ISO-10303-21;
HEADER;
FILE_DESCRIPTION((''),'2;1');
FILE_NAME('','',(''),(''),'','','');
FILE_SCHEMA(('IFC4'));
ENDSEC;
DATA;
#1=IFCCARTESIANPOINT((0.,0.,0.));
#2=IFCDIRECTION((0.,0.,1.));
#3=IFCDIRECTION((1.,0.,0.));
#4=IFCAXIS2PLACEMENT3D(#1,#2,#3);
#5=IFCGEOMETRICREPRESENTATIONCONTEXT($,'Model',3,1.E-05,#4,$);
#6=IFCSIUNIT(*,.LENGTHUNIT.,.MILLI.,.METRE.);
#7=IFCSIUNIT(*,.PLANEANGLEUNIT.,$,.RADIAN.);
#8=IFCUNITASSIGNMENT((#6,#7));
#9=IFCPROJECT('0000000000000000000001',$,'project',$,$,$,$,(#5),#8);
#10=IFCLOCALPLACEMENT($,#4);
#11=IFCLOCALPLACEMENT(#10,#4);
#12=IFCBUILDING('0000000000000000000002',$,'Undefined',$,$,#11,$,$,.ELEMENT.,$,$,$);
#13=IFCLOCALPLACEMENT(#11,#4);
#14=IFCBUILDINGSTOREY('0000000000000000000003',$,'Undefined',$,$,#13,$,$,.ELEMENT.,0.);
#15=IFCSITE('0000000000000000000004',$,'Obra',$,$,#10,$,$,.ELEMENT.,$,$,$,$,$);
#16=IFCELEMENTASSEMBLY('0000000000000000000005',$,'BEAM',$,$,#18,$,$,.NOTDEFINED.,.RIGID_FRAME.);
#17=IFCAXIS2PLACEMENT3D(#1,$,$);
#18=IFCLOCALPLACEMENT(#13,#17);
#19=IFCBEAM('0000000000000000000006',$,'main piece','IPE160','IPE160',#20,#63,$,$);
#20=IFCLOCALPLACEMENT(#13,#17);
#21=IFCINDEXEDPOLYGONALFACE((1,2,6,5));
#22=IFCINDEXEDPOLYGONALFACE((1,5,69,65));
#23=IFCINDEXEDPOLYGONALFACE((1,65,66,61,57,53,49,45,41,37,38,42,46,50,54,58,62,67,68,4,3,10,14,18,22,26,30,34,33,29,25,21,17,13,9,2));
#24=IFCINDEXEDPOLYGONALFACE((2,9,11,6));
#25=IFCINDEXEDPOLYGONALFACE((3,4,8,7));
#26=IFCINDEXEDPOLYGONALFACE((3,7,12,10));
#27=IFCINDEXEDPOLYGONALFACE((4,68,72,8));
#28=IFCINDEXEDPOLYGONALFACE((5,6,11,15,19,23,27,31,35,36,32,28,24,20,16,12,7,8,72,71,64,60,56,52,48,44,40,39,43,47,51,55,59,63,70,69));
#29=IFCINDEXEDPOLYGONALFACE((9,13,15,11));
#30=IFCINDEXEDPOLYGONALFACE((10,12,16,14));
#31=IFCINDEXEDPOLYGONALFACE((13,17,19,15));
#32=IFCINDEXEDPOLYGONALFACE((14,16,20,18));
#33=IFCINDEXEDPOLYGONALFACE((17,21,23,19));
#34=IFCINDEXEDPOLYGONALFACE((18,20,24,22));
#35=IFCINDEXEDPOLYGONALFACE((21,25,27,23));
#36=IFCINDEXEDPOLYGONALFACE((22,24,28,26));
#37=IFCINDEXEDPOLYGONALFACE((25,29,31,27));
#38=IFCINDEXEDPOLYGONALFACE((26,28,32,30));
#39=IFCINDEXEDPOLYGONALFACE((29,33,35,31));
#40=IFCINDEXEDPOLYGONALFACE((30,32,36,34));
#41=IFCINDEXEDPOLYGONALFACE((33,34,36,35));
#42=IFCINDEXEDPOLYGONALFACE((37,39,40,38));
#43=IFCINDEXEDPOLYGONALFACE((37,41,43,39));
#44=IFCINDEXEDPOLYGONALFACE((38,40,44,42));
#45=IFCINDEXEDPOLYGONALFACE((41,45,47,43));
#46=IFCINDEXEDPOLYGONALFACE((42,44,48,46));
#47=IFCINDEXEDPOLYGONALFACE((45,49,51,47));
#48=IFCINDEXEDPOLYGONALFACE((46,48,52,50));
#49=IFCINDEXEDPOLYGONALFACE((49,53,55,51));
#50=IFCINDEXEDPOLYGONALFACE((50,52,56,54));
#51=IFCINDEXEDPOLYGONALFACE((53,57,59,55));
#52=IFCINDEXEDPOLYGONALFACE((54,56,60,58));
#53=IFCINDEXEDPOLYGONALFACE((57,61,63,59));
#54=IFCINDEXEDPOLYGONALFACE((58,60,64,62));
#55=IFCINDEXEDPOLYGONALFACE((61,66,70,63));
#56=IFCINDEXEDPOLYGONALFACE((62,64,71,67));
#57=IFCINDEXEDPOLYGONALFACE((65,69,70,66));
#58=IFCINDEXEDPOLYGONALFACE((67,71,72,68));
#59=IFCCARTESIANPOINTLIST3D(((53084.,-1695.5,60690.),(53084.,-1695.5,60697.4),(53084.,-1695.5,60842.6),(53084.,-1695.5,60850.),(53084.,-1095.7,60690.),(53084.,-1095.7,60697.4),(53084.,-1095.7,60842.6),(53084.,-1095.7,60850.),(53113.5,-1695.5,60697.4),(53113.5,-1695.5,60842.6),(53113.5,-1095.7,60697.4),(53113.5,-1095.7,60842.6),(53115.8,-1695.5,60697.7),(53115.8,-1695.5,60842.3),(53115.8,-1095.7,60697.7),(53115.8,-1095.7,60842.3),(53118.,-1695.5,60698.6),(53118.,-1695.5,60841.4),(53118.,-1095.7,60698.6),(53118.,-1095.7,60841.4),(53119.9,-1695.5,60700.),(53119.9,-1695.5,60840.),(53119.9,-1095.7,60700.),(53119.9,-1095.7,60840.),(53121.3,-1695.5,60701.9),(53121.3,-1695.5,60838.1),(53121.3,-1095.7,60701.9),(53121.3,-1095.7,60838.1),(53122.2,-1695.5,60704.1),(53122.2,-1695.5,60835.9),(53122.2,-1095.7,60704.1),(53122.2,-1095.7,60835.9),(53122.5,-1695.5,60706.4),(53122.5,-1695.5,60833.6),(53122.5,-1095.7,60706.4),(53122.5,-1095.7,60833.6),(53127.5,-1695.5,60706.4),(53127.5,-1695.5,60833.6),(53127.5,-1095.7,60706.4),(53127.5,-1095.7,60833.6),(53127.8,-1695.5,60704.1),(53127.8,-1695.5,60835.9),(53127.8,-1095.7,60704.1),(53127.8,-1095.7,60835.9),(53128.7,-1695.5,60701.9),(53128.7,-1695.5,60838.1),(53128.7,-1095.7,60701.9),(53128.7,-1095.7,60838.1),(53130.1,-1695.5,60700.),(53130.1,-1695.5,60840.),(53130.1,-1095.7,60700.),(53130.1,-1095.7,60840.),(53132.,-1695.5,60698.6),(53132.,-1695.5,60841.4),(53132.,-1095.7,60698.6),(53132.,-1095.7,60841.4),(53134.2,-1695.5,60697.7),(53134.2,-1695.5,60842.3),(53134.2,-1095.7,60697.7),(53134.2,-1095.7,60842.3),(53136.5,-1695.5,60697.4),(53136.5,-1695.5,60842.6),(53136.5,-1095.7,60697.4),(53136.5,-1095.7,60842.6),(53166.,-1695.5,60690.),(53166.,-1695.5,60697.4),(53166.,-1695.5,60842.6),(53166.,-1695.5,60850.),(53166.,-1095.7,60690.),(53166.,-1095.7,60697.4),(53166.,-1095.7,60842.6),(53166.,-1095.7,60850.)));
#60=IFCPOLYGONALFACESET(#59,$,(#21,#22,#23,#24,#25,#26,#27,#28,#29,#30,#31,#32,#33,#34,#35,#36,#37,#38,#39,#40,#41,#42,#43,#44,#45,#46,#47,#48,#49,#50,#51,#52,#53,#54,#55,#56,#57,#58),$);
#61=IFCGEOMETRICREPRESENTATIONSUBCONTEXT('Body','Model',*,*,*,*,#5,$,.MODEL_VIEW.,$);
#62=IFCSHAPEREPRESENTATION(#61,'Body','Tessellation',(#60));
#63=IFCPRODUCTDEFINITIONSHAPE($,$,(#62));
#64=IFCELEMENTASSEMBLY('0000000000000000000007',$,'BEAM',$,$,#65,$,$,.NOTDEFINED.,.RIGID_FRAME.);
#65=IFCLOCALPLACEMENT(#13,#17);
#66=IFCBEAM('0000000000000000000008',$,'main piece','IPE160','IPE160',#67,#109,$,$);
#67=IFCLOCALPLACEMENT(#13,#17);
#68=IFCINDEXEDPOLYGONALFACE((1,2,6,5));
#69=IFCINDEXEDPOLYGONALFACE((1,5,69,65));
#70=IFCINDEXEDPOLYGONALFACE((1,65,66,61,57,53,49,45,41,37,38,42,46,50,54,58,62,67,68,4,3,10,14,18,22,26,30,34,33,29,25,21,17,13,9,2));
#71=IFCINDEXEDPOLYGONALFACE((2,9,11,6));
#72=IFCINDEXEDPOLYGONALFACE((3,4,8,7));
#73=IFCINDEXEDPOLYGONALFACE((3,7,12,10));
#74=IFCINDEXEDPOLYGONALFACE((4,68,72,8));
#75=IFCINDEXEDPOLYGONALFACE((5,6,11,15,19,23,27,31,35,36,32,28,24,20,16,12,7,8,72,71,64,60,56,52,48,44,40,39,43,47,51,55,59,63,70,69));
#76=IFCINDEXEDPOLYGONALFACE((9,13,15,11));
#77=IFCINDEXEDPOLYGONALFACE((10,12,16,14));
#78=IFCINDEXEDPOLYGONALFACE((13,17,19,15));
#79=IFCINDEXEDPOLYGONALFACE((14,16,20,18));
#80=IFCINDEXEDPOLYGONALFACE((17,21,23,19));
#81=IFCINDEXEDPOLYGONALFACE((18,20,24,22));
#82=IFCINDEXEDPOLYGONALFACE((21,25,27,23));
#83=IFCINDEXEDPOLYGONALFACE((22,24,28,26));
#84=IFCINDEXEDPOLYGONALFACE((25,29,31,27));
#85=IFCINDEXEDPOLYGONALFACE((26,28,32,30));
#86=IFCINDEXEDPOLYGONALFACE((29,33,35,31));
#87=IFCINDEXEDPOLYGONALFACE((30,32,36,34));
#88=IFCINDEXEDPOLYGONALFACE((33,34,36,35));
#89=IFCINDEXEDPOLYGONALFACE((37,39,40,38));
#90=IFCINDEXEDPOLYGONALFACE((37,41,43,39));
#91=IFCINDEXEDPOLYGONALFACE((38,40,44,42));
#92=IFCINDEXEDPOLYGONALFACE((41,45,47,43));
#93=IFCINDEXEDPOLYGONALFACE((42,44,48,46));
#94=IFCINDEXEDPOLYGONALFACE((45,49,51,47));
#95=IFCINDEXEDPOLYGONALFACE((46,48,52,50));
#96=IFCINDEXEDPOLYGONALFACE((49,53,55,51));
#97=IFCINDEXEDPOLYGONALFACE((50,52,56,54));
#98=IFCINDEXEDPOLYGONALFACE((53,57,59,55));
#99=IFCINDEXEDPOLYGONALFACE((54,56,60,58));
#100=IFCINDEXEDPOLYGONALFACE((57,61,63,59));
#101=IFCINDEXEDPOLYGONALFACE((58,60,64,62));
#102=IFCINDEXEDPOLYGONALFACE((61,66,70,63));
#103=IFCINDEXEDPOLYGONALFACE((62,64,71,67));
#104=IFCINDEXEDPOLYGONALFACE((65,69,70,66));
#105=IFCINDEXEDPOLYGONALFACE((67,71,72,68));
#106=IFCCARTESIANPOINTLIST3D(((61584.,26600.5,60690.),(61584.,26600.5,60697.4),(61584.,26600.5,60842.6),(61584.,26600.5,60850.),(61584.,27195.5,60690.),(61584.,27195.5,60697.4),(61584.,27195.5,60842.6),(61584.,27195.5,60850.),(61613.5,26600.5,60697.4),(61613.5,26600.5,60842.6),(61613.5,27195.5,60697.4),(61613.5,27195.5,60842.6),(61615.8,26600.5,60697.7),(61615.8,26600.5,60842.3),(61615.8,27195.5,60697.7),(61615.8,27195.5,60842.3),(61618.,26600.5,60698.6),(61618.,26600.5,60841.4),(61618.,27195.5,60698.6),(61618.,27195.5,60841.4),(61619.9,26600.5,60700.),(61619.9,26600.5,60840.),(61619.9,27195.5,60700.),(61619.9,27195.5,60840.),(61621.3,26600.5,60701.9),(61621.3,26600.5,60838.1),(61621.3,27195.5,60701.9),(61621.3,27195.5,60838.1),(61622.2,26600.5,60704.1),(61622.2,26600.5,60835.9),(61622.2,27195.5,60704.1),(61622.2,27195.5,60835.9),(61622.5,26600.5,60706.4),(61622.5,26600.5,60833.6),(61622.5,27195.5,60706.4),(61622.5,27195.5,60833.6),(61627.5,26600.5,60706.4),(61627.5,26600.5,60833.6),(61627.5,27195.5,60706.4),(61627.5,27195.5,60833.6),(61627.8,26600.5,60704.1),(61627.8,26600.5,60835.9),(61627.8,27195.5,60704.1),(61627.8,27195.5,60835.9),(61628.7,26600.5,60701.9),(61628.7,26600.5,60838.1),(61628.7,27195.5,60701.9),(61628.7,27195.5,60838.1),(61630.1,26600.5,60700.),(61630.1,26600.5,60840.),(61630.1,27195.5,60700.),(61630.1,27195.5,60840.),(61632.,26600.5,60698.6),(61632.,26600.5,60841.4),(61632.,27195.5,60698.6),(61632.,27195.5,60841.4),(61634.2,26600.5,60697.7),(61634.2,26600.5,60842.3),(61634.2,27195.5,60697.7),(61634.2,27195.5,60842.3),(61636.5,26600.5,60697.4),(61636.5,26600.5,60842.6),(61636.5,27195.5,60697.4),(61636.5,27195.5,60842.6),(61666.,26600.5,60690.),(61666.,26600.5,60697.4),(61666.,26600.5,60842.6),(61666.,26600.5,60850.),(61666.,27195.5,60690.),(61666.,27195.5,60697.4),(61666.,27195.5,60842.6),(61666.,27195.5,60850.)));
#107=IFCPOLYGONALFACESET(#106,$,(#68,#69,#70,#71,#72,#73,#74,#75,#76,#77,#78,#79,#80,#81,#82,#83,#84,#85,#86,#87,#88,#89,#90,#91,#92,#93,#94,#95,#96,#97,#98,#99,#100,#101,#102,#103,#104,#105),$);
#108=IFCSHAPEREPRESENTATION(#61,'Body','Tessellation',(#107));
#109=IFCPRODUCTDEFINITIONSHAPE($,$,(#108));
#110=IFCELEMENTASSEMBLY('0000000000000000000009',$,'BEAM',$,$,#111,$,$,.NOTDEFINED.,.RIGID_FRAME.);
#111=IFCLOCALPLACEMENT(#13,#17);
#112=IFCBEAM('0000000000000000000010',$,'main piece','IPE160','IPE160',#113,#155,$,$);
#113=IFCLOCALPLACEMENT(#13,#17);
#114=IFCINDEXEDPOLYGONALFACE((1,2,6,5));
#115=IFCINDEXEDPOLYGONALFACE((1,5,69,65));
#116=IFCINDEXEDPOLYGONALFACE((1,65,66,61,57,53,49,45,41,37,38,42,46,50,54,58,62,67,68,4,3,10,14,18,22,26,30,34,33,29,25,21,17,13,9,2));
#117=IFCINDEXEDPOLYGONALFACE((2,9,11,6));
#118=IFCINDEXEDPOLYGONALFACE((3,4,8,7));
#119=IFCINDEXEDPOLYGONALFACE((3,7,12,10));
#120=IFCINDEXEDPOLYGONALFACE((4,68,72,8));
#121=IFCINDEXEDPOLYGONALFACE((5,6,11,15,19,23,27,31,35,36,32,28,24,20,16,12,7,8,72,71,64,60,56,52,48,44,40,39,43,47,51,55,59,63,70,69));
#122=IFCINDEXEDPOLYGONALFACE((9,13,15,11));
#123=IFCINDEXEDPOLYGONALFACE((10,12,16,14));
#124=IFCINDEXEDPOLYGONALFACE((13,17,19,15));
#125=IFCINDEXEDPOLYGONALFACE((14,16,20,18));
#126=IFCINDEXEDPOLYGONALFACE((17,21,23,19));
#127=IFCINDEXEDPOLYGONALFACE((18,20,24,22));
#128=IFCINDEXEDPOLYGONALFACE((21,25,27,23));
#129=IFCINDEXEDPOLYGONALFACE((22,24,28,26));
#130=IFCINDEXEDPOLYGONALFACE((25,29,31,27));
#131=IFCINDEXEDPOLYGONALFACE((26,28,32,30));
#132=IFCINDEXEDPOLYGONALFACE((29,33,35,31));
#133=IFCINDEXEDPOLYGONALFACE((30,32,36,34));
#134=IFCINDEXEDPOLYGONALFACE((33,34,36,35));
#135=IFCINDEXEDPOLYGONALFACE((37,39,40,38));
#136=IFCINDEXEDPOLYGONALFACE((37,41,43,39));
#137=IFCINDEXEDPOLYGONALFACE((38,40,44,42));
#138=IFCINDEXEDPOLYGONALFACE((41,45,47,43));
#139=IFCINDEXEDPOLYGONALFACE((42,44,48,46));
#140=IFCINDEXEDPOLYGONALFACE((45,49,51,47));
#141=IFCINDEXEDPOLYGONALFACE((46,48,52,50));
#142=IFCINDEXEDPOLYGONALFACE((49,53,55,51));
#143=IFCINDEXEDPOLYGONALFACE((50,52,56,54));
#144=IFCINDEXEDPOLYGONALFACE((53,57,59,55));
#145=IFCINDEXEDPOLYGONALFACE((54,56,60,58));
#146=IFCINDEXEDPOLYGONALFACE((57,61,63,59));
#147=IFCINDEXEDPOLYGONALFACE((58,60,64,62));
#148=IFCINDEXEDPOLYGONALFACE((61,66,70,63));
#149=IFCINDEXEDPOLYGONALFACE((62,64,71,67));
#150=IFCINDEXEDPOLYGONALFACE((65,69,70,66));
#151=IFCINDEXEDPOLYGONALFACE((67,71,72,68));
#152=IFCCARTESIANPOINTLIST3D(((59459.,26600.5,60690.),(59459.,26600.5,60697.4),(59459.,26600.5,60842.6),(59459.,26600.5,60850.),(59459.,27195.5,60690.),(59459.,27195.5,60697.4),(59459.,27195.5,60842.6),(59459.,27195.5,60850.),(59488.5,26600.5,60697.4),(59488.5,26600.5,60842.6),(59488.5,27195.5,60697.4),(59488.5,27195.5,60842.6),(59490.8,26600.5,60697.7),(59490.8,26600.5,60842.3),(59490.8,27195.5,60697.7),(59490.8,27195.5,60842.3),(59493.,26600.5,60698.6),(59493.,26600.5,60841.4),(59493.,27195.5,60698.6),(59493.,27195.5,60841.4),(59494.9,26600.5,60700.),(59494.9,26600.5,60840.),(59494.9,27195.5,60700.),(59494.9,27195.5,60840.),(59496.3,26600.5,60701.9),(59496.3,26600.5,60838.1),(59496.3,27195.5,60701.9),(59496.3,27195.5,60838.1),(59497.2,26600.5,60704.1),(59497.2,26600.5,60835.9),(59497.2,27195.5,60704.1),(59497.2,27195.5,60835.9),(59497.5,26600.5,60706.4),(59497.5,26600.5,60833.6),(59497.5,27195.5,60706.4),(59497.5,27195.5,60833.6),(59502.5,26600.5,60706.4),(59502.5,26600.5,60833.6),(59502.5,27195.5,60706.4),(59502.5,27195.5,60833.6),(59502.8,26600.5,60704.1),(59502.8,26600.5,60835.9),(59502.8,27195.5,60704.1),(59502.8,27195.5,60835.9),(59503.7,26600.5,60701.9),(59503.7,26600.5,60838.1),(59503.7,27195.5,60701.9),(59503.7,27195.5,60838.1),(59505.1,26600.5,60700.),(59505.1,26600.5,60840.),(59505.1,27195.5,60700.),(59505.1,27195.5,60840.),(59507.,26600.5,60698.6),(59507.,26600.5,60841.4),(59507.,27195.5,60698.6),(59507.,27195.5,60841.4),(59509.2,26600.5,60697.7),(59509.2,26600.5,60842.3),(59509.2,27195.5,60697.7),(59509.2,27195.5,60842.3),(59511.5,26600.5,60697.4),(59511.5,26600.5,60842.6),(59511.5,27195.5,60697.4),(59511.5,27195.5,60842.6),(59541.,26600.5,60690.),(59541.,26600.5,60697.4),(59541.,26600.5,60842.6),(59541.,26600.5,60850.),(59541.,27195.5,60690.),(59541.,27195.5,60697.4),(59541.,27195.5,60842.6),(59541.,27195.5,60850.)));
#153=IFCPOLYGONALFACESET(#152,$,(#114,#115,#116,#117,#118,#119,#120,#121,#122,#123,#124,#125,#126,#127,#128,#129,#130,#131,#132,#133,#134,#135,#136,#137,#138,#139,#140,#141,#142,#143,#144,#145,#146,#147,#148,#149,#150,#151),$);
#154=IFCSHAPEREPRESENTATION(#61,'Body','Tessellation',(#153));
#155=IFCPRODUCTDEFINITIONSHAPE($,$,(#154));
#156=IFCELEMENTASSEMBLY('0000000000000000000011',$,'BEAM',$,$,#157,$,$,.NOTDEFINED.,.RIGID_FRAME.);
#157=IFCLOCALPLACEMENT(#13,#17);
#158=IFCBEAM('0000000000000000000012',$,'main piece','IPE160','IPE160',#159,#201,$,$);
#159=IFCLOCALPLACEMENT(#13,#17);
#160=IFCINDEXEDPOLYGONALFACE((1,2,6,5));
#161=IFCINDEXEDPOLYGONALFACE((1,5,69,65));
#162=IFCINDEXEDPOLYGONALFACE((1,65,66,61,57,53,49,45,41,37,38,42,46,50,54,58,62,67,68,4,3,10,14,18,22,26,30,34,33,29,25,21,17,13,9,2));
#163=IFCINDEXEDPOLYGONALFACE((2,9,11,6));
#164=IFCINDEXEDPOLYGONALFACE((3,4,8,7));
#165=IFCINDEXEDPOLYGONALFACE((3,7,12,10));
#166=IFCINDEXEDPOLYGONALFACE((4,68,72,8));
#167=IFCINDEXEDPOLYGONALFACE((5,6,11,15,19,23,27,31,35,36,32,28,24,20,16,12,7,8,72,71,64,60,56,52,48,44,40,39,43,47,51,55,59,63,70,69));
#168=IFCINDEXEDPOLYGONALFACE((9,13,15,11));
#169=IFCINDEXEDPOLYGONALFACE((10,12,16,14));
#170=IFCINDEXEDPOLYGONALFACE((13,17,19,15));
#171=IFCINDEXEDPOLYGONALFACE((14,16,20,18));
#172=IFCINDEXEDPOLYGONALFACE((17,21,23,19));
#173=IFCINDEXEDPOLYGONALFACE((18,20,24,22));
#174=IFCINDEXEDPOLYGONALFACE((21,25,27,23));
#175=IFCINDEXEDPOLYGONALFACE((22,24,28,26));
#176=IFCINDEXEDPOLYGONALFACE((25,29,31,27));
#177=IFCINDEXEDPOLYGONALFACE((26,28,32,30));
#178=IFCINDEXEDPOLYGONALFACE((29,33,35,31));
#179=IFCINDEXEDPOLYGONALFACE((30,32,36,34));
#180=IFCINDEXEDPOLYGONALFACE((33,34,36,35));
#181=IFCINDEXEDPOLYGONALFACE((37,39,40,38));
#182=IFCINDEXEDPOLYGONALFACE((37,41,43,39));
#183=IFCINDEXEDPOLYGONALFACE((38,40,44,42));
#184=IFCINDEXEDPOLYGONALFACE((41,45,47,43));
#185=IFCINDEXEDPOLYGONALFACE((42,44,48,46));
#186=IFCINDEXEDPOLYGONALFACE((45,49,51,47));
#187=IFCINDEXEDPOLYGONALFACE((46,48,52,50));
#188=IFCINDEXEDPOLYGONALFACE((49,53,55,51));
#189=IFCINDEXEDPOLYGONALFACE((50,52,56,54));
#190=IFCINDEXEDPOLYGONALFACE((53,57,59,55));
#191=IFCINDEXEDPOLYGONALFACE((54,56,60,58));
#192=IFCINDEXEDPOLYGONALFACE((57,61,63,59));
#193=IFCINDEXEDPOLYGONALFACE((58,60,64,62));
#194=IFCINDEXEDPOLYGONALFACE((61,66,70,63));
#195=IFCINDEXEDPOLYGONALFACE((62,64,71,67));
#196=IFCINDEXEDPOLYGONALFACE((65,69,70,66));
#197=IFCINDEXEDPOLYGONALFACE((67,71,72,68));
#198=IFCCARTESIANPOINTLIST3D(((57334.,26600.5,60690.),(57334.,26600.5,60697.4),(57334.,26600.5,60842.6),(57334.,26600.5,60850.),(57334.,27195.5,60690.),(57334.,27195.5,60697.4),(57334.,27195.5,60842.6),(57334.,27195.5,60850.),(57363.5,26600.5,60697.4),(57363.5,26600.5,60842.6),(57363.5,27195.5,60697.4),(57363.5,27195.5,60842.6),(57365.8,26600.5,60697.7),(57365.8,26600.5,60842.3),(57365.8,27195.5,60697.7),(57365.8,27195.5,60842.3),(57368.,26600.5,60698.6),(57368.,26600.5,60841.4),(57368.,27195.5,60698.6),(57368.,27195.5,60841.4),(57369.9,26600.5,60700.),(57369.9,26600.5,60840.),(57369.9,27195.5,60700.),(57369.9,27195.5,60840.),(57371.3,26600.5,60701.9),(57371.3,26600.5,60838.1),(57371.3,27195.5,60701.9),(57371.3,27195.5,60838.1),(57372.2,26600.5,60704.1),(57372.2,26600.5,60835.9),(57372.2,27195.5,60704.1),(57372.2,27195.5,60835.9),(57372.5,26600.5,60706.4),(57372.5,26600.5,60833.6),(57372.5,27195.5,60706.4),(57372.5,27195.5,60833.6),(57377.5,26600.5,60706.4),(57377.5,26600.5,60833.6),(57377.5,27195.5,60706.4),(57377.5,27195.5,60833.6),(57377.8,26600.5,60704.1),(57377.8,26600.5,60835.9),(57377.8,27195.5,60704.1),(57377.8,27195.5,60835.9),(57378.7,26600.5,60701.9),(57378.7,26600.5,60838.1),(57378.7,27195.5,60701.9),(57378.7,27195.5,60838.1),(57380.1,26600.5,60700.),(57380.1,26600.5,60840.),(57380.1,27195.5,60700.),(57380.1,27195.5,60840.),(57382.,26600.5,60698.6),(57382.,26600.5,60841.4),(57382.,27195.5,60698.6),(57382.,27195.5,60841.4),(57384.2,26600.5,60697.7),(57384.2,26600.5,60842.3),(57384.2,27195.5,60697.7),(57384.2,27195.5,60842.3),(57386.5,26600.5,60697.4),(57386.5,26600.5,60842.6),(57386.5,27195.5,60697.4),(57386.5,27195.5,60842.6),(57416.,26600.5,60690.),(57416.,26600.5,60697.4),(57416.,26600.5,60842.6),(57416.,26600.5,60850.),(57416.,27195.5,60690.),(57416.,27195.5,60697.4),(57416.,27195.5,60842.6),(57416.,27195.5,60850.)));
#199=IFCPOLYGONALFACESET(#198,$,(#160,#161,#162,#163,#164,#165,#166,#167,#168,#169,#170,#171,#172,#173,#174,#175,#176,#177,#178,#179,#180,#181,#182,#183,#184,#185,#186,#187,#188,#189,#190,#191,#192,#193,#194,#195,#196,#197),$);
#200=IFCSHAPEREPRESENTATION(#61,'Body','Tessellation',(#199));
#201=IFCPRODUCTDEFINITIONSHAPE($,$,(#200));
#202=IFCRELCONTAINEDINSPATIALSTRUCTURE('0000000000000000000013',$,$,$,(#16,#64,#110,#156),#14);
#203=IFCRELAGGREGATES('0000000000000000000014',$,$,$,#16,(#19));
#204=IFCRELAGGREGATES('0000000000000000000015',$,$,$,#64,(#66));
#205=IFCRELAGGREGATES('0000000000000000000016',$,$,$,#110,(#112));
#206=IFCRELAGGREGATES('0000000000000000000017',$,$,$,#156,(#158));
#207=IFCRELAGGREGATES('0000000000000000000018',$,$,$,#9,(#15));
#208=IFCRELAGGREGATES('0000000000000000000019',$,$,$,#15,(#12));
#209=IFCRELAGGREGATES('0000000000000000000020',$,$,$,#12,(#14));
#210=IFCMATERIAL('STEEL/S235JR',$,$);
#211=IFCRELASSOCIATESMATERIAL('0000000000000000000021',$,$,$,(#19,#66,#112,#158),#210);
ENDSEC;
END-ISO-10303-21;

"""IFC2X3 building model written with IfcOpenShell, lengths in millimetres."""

from ifc_helpers import new_model, si_unit, frame, origin_with_axes, origin_2d_with_axis, place, context, subcontext, project, spatial, i_section, extrude, material, element, aggregate, save


model = new_model("IFC2X3")

# Units and contexts
model_context = context("Model", 3, precision=1e-05, world=origin_with_axes())
body_context = subcontext(model_context, "Body", "Model", "MODEL_VIEW")
ifc_project = project(units=[si_unit("LENGTHUNIT", "METRE", prefix="MILLI"), si_unit("PLANEANGLEUNIT", "RADIAN")], contexts=[model_context])

# Site, building, storey
site_placement = place(None, origin_with_axes())
site = spatial("IfcSite", under=ifc_project, at=site_placement, Name="Obra", CompositionType="ELEMENT")
building_placement = place(site_placement, origin_with_axes())
building = spatial("IfcBuilding", under=site, at=building_placement, Name="Undefined", CompositionType="ELEMENT")
storey_placement = place(building_placement, origin_with_axes())
storey = spatial("IfcBuildingStorey", under=building, at=storey_placement, Name="Undefined", CompositionType="ELEMENT", Elevation=0.0)

# Element assemblies, beams
ifc_material_1 = material(Name="STEEL/S235JR")
assembly_1_placement = place(storey_placement, origin_with_axes())
assembly_1 = element("IfcElementAssembly", 1, at=assembly_1_placement, inside=storey, Name="BEAM", AssemblyPlace="NOTDEFINED", PredefinedType="RIGID_FRAME")
beam_1_placement = place(assembly_1_placement, frame((53125.0, -1095.7, 60770.0), z_axis=(0.0, 0.0, 1.0), x_axis=(0.0, -1.0, 0.0)))
beam_1 = element("IfcBeam", 2, at=beam_1_placement, material=ifc_material_1, Name="main piece", Description="IPE160", ObjectType="IPE160", context=body_context, shape_type="SweptSolid", body=[
    extrude(i_section(OverallWidth=82.0, OverallDepth=160.0, WebThickness=5.0, FlangeThickness=7.4, FilletRadius=9.0, at=origin_2d_with_axis()), frame((599.8, 0.0, 0.0), z_axis=(-1.0, 0.0, 0.0), x_axis=(0.0, -1.0, 0.0)), (0.0, 0.0, 1.0), 599.8),
])
aggregate(assembly_1, [beam_1])
assembly_2_placement = place(storey_placement, origin_with_axes())
assembly_2 = element("IfcElementAssembly", 3, at=assembly_2_placement, inside=storey, Name="BEAM", AssemblyPlace="NOTDEFINED", PredefinedType="RIGID_FRAME")
beam_2_placement = place(assembly_2_placement, frame((61625.0, 27195.5, 60770.0), z_axis=(0.0, 0.0, 1.0), x_axis=(0.0, -1.0, 0.0)))
beam_2 = element("IfcBeam", 4, at=beam_2_placement, material=ifc_material_1, Name="main piece", Description="IPE160", ObjectType="IPE160", context=body_context, shape_type="SweptSolid", body=[
    extrude(i_section(OverallWidth=82.0, OverallDepth=160.0, WebThickness=5.0, FlangeThickness=7.4, FilletRadius=9.0, at=origin_2d_with_axis()), frame((595.0, 0.0, 0.0), z_axis=(-1.0, 0.0, 0.0), x_axis=(0.0, -1.0, 0.0)), (0.0, 0.0, 1.0), 595.0),
])
aggregate(assembly_2, [beam_2])
assembly_3_placement = place(storey_placement, origin_with_axes())
assembly_3 = element("IfcElementAssembly", 5, at=assembly_3_placement, inside=storey, Name="BEAM", AssemblyPlace="NOTDEFINED", PredefinedType="RIGID_FRAME")
beam_3_placement = place(assembly_3_placement, frame((59500.0, 26600.5, 60770.0), z_axis=(0.0, 0.0, 1.0), x_axis=(0.0, 1.0, 0.0)))
beam_3 = element("IfcBeam", 6, at=beam_3_placement, material=ifc_material_1, Name="main piece", Description="IPE160", ObjectType="IPE160", context=body_context, shape_type="SweptSolid", body=[
    extrude(i_section(OverallWidth=82.0, OverallDepth=160.0, WebThickness=5.0, FlangeThickness=7.4, FilletRadius=9.0, at=origin_2d_with_axis()), frame((595.0, 0.0, 0.0), z_axis=(-1.0, 0.0, 0.0), x_axis=(0.0, -1.0, 0.0)), (0.0, 0.0, 1.0), 595.0),
])
aggregate(assembly_3, [beam_3])
assembly_4_placement = place(storey_placement, origin_with_axes())
assembly_4 = element("IfcElementAssembly", 7, at=assembly_4_placement, inside=storey, Name="BEAM", AssemblyPlace="NOTDEFINED", PredefinedType="RIGID_FRAME")
beam_4_placement = place(assembly_4_placement, frame((57375.0, 27195.5, 60770.0), z_axis=(0.0, 0.0, 1.0), x_axis=(0.0, -1.0, 0.0)))
beam_4 = element("IfcBeam", 8, at=beam_4_placement, material=ifc_material_1, Name="main piece", Description="IPE160", ObjectType="IPE160", context=body_context, shape_type="SweptSolid", body=[
    extrude(i_section(OverallWidth=82.0, OverallDepth=160.0, WebThickness=5.0, FlangeThickness=7.4, FilletRadius=9.0, at=origin_2d_with_axis()), frame((595.0, 0.0, 0.0), z_axis=(-1.0, 0.0, 0.0), x_axis=(0.0, -1.0, 0.0)), (0.0, 0.0, 1.0), 595.0),
])
aggregate(assembly_4, [beam_4])

save(model, "model.ifc")
